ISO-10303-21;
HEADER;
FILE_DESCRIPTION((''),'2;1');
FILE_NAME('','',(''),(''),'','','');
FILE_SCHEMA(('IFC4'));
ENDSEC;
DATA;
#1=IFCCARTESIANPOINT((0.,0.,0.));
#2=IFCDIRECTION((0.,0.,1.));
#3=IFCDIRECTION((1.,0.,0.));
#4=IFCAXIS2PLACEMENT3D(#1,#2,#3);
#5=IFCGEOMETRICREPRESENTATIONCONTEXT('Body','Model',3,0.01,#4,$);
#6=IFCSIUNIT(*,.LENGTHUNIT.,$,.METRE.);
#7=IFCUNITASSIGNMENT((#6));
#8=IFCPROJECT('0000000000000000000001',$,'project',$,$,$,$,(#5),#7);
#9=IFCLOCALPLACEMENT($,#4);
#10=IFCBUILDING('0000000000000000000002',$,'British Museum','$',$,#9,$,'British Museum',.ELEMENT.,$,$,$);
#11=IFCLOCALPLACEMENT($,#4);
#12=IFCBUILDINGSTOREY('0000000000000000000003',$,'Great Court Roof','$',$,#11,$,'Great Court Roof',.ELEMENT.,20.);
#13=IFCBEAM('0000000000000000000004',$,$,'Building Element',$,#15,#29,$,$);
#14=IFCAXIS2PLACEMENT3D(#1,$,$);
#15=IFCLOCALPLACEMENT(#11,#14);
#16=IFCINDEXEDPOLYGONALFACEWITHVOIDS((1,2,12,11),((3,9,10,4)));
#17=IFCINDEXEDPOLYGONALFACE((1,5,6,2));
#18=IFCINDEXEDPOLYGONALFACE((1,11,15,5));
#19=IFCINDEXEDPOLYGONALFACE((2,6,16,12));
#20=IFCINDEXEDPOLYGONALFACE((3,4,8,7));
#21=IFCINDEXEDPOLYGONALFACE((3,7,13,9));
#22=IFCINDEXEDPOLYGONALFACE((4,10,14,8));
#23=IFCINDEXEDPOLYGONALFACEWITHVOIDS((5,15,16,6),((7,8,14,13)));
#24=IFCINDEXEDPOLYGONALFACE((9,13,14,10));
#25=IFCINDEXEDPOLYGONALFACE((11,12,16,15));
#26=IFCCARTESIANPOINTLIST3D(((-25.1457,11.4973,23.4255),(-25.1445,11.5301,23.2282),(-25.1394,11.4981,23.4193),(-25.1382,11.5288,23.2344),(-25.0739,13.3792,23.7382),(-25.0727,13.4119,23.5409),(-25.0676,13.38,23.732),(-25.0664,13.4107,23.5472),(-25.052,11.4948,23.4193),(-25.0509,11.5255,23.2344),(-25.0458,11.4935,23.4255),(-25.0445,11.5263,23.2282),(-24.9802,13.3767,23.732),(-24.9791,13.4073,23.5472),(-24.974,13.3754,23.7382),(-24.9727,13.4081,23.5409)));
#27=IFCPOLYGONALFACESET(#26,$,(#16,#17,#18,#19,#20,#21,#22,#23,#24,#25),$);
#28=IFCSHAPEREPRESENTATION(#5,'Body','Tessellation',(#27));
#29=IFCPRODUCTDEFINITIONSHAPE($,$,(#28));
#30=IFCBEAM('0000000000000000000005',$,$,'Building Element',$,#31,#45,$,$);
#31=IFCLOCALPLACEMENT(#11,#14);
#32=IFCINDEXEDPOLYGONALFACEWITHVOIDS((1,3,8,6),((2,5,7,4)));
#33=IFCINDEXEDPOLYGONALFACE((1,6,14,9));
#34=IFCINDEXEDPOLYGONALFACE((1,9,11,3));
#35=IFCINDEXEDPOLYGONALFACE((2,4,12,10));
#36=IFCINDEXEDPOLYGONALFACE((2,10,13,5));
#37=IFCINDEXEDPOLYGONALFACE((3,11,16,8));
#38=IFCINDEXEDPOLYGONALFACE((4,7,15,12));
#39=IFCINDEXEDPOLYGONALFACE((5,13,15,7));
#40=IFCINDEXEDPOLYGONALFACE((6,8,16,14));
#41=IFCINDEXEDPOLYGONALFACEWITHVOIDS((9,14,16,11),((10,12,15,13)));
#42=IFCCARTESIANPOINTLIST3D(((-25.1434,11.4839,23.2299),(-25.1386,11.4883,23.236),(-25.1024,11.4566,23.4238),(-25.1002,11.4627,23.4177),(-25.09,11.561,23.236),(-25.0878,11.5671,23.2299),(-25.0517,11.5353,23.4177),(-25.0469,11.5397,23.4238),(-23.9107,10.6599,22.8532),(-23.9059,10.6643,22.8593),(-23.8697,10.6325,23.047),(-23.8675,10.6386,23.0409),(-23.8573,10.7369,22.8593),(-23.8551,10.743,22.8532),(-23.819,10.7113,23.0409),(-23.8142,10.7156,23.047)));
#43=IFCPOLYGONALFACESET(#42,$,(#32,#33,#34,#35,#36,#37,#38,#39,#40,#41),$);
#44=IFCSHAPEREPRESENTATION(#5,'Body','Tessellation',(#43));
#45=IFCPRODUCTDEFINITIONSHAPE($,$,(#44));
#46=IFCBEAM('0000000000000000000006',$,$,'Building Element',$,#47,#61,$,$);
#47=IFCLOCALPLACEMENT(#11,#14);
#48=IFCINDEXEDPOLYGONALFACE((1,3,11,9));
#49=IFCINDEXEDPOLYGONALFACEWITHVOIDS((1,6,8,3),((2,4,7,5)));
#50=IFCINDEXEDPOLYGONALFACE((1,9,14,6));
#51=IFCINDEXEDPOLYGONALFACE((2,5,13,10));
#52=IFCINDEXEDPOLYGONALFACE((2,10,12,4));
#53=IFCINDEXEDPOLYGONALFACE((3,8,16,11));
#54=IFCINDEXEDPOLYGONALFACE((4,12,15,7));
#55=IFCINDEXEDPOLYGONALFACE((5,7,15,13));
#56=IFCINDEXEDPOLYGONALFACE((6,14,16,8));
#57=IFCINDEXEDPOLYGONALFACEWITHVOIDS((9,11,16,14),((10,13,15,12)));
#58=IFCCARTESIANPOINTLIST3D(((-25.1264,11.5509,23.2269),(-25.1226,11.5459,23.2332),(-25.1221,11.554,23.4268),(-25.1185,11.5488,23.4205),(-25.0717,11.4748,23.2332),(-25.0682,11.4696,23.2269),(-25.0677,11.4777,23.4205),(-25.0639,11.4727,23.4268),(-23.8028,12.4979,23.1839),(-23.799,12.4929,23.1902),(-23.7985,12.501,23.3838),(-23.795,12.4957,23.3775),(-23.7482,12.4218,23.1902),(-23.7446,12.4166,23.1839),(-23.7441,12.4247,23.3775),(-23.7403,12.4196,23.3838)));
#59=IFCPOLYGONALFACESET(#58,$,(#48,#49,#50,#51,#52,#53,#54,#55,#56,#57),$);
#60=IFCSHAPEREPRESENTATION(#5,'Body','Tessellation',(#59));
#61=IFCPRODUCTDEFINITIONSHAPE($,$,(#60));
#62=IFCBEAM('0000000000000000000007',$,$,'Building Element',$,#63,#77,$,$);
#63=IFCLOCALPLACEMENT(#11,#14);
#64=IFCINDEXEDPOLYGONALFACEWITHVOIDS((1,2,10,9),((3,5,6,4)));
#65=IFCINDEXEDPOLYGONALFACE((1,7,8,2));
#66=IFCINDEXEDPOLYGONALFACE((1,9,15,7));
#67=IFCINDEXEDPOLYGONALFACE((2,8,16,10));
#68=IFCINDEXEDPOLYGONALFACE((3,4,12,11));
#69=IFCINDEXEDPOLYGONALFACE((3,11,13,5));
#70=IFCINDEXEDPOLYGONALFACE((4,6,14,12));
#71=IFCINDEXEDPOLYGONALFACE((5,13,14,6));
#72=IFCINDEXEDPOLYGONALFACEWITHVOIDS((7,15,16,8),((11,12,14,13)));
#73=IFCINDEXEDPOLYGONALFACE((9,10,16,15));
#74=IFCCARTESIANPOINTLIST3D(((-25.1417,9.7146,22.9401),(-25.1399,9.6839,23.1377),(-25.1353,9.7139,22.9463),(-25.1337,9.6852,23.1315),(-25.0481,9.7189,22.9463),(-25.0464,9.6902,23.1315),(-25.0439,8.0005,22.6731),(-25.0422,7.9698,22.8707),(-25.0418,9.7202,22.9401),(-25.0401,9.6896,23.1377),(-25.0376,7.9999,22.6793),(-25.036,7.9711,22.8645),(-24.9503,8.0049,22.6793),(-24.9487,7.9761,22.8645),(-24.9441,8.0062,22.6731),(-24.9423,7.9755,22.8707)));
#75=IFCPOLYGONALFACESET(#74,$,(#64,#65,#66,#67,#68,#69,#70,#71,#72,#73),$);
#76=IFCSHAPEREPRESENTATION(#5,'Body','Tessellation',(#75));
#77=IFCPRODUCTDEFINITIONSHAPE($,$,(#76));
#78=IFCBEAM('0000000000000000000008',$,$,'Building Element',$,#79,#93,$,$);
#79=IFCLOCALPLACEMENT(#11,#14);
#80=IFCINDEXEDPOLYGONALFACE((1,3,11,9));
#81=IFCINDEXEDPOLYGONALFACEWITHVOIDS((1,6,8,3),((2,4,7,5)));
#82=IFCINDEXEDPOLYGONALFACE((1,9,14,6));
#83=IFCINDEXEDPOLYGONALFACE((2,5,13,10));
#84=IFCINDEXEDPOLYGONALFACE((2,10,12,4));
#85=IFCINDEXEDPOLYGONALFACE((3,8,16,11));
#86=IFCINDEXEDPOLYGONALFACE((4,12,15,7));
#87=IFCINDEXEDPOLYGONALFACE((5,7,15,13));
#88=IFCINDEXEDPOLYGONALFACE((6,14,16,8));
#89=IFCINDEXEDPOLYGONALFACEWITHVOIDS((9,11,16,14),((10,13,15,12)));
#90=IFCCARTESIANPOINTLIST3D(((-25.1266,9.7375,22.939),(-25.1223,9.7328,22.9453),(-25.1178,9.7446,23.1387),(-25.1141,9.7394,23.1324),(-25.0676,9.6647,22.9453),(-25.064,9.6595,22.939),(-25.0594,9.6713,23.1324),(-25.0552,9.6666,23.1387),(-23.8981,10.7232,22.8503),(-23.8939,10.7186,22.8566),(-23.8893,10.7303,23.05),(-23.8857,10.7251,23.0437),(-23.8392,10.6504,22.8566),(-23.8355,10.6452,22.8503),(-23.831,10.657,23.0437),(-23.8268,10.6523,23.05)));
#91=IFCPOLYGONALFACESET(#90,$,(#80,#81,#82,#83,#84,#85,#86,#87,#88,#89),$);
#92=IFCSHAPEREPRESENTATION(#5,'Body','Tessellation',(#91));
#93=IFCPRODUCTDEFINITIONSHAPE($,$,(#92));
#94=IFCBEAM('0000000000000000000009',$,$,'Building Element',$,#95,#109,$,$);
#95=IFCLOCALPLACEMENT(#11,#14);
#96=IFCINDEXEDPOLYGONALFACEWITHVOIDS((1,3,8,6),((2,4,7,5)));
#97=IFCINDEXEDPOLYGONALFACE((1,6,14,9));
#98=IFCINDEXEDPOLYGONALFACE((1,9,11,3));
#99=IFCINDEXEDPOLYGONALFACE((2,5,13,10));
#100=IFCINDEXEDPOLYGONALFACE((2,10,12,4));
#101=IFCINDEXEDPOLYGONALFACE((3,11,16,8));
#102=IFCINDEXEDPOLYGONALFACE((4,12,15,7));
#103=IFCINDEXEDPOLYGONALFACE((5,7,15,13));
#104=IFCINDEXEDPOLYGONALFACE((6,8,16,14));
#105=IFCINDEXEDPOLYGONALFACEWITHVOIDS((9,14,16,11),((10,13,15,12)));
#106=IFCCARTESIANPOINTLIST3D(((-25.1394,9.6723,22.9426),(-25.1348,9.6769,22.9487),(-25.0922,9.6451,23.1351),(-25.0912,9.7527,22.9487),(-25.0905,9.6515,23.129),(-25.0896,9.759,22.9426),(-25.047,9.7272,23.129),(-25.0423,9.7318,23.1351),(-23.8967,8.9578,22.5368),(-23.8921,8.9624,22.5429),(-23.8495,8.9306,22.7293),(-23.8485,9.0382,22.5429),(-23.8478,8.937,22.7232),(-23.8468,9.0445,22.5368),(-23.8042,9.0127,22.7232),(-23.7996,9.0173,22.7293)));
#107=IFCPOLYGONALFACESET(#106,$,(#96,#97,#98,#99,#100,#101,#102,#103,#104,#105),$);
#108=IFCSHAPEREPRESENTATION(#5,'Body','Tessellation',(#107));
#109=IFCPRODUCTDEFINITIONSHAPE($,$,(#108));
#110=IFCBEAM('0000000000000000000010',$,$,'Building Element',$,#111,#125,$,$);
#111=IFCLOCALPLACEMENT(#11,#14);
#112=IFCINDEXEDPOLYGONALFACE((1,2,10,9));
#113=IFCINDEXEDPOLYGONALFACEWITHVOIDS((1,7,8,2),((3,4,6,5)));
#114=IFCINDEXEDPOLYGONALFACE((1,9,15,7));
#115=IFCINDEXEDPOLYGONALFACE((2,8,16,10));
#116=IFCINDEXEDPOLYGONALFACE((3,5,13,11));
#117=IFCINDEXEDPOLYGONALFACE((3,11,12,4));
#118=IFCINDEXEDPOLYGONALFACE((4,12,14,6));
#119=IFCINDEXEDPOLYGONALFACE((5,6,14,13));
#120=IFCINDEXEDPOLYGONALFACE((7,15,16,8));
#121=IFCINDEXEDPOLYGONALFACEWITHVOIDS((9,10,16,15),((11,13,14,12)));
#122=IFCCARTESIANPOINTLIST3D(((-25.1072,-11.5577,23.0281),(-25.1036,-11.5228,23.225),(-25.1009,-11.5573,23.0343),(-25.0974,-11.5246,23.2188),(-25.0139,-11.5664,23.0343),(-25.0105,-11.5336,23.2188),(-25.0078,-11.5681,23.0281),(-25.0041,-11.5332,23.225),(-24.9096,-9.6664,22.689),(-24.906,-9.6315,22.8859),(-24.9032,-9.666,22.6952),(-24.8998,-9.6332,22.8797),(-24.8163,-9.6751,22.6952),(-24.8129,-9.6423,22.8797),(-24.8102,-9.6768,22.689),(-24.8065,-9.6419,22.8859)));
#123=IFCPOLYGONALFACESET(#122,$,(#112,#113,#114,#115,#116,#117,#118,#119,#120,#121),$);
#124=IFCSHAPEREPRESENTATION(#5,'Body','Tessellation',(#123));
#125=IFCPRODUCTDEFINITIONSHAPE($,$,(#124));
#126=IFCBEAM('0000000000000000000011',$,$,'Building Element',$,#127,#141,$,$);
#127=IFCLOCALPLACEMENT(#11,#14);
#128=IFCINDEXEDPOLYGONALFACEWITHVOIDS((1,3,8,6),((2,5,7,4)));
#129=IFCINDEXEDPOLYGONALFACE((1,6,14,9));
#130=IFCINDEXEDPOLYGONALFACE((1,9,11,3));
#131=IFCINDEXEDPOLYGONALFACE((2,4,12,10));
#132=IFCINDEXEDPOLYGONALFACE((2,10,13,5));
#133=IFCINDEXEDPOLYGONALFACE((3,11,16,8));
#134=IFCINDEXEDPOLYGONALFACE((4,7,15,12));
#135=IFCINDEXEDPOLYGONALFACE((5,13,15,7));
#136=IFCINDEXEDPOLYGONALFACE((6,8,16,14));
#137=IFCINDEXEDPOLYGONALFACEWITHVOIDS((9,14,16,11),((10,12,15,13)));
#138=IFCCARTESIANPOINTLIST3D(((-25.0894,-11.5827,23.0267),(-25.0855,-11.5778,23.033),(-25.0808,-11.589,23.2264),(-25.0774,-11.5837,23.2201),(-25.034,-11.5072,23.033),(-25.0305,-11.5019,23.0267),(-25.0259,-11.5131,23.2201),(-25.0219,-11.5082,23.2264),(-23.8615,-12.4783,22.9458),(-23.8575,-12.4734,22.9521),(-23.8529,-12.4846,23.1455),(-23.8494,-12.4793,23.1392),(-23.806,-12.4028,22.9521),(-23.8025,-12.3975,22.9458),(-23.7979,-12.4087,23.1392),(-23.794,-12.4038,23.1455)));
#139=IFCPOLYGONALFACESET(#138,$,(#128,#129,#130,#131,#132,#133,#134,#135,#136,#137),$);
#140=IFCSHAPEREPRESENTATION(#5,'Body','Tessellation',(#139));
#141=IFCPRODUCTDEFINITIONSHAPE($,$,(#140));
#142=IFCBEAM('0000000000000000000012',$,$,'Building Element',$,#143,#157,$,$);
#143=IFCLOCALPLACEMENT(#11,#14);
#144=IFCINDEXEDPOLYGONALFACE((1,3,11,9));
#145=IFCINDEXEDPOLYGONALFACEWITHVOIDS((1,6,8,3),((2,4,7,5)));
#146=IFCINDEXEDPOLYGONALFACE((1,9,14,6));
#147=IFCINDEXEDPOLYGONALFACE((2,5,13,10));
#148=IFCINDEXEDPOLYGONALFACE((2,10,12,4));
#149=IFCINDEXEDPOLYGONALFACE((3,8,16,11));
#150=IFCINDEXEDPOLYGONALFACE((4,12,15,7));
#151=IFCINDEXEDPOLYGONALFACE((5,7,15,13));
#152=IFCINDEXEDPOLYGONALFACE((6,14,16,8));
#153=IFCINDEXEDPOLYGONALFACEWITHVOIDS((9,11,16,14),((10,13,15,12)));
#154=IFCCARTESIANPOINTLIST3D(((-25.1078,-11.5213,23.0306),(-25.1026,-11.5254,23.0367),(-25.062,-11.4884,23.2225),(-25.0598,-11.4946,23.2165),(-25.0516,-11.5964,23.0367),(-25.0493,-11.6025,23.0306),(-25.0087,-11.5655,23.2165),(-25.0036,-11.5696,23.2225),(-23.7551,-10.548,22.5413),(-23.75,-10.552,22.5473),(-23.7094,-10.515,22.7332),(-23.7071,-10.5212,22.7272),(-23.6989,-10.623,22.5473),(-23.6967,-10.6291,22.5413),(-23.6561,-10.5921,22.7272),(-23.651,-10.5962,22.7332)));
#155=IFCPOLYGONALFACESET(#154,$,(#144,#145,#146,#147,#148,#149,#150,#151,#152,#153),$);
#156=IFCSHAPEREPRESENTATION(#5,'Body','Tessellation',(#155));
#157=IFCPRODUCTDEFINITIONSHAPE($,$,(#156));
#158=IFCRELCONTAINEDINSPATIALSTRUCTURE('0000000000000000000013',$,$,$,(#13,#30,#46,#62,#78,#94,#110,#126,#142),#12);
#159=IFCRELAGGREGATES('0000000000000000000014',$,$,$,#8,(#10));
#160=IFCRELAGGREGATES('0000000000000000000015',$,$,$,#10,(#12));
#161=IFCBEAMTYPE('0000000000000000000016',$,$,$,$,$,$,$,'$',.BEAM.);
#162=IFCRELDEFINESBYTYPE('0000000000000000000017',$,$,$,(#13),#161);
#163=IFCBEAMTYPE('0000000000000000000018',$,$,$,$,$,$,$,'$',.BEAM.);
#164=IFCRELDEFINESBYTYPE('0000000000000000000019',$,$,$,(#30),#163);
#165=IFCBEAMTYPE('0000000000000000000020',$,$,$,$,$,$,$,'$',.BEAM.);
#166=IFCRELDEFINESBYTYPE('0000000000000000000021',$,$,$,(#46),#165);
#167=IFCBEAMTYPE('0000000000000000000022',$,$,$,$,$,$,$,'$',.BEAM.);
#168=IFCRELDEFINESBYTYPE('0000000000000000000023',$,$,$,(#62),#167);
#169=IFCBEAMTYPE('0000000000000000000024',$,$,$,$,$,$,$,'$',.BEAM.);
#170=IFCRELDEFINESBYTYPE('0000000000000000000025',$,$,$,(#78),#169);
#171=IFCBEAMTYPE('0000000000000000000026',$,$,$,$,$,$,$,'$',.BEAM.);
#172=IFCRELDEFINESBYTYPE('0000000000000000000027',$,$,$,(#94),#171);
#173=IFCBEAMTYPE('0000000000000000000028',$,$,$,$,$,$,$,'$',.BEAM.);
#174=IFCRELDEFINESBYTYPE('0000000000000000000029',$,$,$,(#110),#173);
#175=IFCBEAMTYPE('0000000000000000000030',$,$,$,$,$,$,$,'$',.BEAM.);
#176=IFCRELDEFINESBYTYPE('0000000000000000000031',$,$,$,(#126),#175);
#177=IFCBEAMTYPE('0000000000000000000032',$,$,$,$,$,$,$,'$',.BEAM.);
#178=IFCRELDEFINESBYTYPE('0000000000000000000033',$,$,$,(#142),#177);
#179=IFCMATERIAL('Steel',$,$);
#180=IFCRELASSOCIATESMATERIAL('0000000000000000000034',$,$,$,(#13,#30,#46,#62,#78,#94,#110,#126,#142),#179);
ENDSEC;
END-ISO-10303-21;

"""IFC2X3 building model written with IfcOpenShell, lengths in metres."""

from ifc_helpers import new_model, si_unit, frame, origin_with_axes, origin_2d, place, context, project, spatial, hollow_rectangle, extrude, material, type_object, element, save


model = new_model("IFC2X3")

# Units and contexts
model_context = context("Model", 3, precision=0.01, world=origin_with_axes(), identifier="Body")
ifc_project = project(units=[si_unit("LENGTHUNIT", "METRE")], contexts=[model_context])

# Building, storey
building_placement = place(None, origin_with_axes())
building = spatial("IfcBuilding", under=ifc_project, at=building_placement, Name="British Museum", Description="$", LongName="British Museum", CompositionType="ELEMENT")
storey_placement = place(None, origin_with_axes())
storey = spatial("IfcBuildingStorey", under=building, at=storey_placement, Name="Great Court Roof", Description="$", LongName="Great Court Roof", CompositionType="ELEMENT", Elevation=20.0)

# Beams
ifc_material = material(Name="Steel")
beam_type_1 = type_object("IfcBeamType", ElementType="$", PredefinedType="BEAM")
beam_1_placement = place(None, origin_with_axes())
element("IfcBeam", 1, at=beam_1_placement, inside=storey, type_object=beam_type_1, material=ifc_material, Description="Building Element", context=model_context, shape_type="SweptSolid", body=[
    extrude(hollow_rectangle(XDim=0.1, YDim=0.2, WallThickness=0.0063, InnerFilletRadius=0.0, OuterFilletRadius=0.0, at=origin_2d()), frame((-25.0951, 11.5118, 23.3269), z_axis=(0.03761, 0.985773, 0.163822), x_axis=(-0.999273, 0.038125, 0.0)), (0.0, 0.0, 1.0), 1.909),
])
beam_type_2 = type_object("IfcBeamType", ElementType="$", PredefinedType="BEAM")
beam_2_placement = place(None, origin_with_axes())
element("IfcBeam", 2, at=beam_2_placement, inside=storey, type_object=beam_type_2, material=ifc_material, Description="Building Element", context=model_context, shape_type="SweptSolid", body=[
    extrude(hollow_rectangle(XDim=0.1, YDim=0.2, WallThickness=0.0063, InnerFilletRadius=0.0, OuterFilletRadius=0.0, at=origin_2d()), frame((-25.0951, 11.5118, 23.3269), z_axis=(0.805749, -0.538635, -0.246253), x_axis=(0.555749, 0.83135, 0.0)), (0.0, 0.0, 1.0), 1.5299),
])
beam_type_3 = type_object("IfcBeamType", ElementType="$", PredefinedType="BEAM")
beam_3_placement = place(None, origin_with_axes())
element("IfcBeam", 3, at=beam_3_placement, inside=storey, type_object=beam_type_3, material=ifc_material, Description="Building Element", context=model_context, shape_type="SweptSolid", body=[
    extrude(hollow_rectangle(XDim=0.1, YDim=0.2, WallThickness=0.0063, InnerFilletRadius=0.0, OuterFilletRadius=0.0, at=origin_2d()), frame((-25.0951, 11.5118, 23.3269), z_axis=(0.812996, 0.58167, -0.026425), x_axis=(-0.581873, 0.81328, 0.0)), (0.0, 0.0, 1.0), 1.628),
])
beam_type_4 = type_object("IfcBeamType", ElementType="$", PredefinedType="BEAM")
beam_4_placement = place(None, origin_with_axes())
element("IfcBeam", 4, at=beam_4_placement, inside=storey, type_object=beam_type_4, material=ifc_material, Description="Building Element", context=model_context, shape_type="SweptSolid", body=[
    extrude(hollow_rectangle(XDim=0.1, YDim=0.2, WallThickness=0.0063, InnerFilletRadius=0.0, OuterFilletRadius=0.0, at=origin_2d()), frame((-25.0909, 9.7021, 23.0389), z_axis=(0.056256, -0.986524, -0.153642), x_axis=(0.998378, 0.056932, 0.0)), (0.0, 0.0, 1.0), 1.7375),
])
beam_type_5 = type_object("IfcBeamType", ElementType="$", PredefinedType="BEAM")
beam_5_placement = place(None, origin_with_axes())
element("IfcBeam", 5, at=beam_5_placement, inside=storey, type_object=beam_type_5, material=ifc_material, Description="Building Element", context=model_context, shape_type="SweptSolid", body=[
    extrude(hollow_rectangle(XDim=0.1, YDim=0.2, WallThickness=0.0063, InnerFilletRadius=0.0, OuterFilletRadius=0.0, at=origin_2d()), frame((-25.0909, 9.7021, 23.0389), z_axis=(0.778723, 0.624841, -0.056258), x_axis=(-0.625832, 0.779958, 0.0)), (0.0, 0.0, 1.0), 1.5775),
])
beam_type_6 = type_object("IfcBeamType", ElementType="$", PredefinedType="BEAM")
beam_6_placement = place(None, origin_with_axes())
element("IfcBeam", 6, at=beam_6_placement, inside=storey, type_object=beam_type_6, material=ifc_material, Description="Building Element", context=model_context, shape_type="SweptSolid", body=[
    extrude(hollow_rectangle(XDim=0.1, YDim=0.2, WallThickness=0.0063, InnerFilletRadius=0.0, OuterFilletRadius=0.0, at=origin_2d()), frame((-25.0909, 9.7021, 23.0389), z_axis=(0.834148, -0.479582, -0.272395), x_axis=(0.49843, 0.86693, 0.0)), (0.0, 0.0, 1.0), 1.4898),
])
beam_type_7 = type_object("IfcBeamType", ElementType="$", PredefinedType="BEAM")
beam_7_placement = place(None, origin_with_axes())
element("IfcBeam", 7, at=beam_7_placement, inside=storey, type_object=beam_type_7, material=ifc_material, Description="Building Element", context=model_context, shape_type="SweptSolid", body=[
    extrude(hollow_rectangle(XDim=0.1, YDim=0.2, WallThickness=0.0063, InnerFilletRadius=0.0, OuterFilletRadius=0.0, at=origin_2d()), frame((-25.0557, -11.5455, 23.1266), z_axis=(0.10231, 0.979141, -0.175543), x_axis=(-0.994585, 0.103924, 0.0)), (0.0, 0.0, 1.0), 1.9316),
])
beam_type_8 = type_object("IfcBeamType", ElementType="$", PredefinedType="BEAM")
beam_8_placement = place(None, origin_with_axes())
element("IfcBeam", 8, at=beam_8_placement, inside=storey, type_object=beam_type_8, material=ifc_material, Description="Building Element", context=model_context, shape_type="SweptSolid", body=[
    extrude(hollow_rectangle(XDim=0.1, YDim=0.2, WallThickness=0.0063, InnerFilletRadius=0.0, OuterFilletRadius=0.0, at=origin_2d()), frame((-25.0557, -11.5455, 23.1266), z_axis=(0.806811, -0.588411, -0.053189), x_axis=(0.589245, 0.807955, 0.0)), (0.0, 0.0, 1.0), 1.522),
])
beam_type_9 = type_object("IfcBeamType", ElementType="$", PredefinedType="BEAM")
beam_9_placement = place(None, origin_with_axes())
element("IfcBeam", 9, at=beam_9_placement, inside=storey, type_object=beam_type_9, material=ifc_material, Description="Building Element", context=model_context, shape_type="SweptSolid", body=[
    extrude(hollow_rectangle(XDim=0.1, YDim=0.2, WallThickness=0.0063, InnerFilletRadius=0.0, OuterFilletRadius=0.0, at=origin_2d()), frame((-25.0557, -11.5455, 23.1266), z_axis=(0.778804, 0.560437, -0.281735), x_axis=(-0.584097, 0.811684, 0.0)), (0.0, 0.0, 1.0), 1.7368),
])

save(model, "model.ifc")
